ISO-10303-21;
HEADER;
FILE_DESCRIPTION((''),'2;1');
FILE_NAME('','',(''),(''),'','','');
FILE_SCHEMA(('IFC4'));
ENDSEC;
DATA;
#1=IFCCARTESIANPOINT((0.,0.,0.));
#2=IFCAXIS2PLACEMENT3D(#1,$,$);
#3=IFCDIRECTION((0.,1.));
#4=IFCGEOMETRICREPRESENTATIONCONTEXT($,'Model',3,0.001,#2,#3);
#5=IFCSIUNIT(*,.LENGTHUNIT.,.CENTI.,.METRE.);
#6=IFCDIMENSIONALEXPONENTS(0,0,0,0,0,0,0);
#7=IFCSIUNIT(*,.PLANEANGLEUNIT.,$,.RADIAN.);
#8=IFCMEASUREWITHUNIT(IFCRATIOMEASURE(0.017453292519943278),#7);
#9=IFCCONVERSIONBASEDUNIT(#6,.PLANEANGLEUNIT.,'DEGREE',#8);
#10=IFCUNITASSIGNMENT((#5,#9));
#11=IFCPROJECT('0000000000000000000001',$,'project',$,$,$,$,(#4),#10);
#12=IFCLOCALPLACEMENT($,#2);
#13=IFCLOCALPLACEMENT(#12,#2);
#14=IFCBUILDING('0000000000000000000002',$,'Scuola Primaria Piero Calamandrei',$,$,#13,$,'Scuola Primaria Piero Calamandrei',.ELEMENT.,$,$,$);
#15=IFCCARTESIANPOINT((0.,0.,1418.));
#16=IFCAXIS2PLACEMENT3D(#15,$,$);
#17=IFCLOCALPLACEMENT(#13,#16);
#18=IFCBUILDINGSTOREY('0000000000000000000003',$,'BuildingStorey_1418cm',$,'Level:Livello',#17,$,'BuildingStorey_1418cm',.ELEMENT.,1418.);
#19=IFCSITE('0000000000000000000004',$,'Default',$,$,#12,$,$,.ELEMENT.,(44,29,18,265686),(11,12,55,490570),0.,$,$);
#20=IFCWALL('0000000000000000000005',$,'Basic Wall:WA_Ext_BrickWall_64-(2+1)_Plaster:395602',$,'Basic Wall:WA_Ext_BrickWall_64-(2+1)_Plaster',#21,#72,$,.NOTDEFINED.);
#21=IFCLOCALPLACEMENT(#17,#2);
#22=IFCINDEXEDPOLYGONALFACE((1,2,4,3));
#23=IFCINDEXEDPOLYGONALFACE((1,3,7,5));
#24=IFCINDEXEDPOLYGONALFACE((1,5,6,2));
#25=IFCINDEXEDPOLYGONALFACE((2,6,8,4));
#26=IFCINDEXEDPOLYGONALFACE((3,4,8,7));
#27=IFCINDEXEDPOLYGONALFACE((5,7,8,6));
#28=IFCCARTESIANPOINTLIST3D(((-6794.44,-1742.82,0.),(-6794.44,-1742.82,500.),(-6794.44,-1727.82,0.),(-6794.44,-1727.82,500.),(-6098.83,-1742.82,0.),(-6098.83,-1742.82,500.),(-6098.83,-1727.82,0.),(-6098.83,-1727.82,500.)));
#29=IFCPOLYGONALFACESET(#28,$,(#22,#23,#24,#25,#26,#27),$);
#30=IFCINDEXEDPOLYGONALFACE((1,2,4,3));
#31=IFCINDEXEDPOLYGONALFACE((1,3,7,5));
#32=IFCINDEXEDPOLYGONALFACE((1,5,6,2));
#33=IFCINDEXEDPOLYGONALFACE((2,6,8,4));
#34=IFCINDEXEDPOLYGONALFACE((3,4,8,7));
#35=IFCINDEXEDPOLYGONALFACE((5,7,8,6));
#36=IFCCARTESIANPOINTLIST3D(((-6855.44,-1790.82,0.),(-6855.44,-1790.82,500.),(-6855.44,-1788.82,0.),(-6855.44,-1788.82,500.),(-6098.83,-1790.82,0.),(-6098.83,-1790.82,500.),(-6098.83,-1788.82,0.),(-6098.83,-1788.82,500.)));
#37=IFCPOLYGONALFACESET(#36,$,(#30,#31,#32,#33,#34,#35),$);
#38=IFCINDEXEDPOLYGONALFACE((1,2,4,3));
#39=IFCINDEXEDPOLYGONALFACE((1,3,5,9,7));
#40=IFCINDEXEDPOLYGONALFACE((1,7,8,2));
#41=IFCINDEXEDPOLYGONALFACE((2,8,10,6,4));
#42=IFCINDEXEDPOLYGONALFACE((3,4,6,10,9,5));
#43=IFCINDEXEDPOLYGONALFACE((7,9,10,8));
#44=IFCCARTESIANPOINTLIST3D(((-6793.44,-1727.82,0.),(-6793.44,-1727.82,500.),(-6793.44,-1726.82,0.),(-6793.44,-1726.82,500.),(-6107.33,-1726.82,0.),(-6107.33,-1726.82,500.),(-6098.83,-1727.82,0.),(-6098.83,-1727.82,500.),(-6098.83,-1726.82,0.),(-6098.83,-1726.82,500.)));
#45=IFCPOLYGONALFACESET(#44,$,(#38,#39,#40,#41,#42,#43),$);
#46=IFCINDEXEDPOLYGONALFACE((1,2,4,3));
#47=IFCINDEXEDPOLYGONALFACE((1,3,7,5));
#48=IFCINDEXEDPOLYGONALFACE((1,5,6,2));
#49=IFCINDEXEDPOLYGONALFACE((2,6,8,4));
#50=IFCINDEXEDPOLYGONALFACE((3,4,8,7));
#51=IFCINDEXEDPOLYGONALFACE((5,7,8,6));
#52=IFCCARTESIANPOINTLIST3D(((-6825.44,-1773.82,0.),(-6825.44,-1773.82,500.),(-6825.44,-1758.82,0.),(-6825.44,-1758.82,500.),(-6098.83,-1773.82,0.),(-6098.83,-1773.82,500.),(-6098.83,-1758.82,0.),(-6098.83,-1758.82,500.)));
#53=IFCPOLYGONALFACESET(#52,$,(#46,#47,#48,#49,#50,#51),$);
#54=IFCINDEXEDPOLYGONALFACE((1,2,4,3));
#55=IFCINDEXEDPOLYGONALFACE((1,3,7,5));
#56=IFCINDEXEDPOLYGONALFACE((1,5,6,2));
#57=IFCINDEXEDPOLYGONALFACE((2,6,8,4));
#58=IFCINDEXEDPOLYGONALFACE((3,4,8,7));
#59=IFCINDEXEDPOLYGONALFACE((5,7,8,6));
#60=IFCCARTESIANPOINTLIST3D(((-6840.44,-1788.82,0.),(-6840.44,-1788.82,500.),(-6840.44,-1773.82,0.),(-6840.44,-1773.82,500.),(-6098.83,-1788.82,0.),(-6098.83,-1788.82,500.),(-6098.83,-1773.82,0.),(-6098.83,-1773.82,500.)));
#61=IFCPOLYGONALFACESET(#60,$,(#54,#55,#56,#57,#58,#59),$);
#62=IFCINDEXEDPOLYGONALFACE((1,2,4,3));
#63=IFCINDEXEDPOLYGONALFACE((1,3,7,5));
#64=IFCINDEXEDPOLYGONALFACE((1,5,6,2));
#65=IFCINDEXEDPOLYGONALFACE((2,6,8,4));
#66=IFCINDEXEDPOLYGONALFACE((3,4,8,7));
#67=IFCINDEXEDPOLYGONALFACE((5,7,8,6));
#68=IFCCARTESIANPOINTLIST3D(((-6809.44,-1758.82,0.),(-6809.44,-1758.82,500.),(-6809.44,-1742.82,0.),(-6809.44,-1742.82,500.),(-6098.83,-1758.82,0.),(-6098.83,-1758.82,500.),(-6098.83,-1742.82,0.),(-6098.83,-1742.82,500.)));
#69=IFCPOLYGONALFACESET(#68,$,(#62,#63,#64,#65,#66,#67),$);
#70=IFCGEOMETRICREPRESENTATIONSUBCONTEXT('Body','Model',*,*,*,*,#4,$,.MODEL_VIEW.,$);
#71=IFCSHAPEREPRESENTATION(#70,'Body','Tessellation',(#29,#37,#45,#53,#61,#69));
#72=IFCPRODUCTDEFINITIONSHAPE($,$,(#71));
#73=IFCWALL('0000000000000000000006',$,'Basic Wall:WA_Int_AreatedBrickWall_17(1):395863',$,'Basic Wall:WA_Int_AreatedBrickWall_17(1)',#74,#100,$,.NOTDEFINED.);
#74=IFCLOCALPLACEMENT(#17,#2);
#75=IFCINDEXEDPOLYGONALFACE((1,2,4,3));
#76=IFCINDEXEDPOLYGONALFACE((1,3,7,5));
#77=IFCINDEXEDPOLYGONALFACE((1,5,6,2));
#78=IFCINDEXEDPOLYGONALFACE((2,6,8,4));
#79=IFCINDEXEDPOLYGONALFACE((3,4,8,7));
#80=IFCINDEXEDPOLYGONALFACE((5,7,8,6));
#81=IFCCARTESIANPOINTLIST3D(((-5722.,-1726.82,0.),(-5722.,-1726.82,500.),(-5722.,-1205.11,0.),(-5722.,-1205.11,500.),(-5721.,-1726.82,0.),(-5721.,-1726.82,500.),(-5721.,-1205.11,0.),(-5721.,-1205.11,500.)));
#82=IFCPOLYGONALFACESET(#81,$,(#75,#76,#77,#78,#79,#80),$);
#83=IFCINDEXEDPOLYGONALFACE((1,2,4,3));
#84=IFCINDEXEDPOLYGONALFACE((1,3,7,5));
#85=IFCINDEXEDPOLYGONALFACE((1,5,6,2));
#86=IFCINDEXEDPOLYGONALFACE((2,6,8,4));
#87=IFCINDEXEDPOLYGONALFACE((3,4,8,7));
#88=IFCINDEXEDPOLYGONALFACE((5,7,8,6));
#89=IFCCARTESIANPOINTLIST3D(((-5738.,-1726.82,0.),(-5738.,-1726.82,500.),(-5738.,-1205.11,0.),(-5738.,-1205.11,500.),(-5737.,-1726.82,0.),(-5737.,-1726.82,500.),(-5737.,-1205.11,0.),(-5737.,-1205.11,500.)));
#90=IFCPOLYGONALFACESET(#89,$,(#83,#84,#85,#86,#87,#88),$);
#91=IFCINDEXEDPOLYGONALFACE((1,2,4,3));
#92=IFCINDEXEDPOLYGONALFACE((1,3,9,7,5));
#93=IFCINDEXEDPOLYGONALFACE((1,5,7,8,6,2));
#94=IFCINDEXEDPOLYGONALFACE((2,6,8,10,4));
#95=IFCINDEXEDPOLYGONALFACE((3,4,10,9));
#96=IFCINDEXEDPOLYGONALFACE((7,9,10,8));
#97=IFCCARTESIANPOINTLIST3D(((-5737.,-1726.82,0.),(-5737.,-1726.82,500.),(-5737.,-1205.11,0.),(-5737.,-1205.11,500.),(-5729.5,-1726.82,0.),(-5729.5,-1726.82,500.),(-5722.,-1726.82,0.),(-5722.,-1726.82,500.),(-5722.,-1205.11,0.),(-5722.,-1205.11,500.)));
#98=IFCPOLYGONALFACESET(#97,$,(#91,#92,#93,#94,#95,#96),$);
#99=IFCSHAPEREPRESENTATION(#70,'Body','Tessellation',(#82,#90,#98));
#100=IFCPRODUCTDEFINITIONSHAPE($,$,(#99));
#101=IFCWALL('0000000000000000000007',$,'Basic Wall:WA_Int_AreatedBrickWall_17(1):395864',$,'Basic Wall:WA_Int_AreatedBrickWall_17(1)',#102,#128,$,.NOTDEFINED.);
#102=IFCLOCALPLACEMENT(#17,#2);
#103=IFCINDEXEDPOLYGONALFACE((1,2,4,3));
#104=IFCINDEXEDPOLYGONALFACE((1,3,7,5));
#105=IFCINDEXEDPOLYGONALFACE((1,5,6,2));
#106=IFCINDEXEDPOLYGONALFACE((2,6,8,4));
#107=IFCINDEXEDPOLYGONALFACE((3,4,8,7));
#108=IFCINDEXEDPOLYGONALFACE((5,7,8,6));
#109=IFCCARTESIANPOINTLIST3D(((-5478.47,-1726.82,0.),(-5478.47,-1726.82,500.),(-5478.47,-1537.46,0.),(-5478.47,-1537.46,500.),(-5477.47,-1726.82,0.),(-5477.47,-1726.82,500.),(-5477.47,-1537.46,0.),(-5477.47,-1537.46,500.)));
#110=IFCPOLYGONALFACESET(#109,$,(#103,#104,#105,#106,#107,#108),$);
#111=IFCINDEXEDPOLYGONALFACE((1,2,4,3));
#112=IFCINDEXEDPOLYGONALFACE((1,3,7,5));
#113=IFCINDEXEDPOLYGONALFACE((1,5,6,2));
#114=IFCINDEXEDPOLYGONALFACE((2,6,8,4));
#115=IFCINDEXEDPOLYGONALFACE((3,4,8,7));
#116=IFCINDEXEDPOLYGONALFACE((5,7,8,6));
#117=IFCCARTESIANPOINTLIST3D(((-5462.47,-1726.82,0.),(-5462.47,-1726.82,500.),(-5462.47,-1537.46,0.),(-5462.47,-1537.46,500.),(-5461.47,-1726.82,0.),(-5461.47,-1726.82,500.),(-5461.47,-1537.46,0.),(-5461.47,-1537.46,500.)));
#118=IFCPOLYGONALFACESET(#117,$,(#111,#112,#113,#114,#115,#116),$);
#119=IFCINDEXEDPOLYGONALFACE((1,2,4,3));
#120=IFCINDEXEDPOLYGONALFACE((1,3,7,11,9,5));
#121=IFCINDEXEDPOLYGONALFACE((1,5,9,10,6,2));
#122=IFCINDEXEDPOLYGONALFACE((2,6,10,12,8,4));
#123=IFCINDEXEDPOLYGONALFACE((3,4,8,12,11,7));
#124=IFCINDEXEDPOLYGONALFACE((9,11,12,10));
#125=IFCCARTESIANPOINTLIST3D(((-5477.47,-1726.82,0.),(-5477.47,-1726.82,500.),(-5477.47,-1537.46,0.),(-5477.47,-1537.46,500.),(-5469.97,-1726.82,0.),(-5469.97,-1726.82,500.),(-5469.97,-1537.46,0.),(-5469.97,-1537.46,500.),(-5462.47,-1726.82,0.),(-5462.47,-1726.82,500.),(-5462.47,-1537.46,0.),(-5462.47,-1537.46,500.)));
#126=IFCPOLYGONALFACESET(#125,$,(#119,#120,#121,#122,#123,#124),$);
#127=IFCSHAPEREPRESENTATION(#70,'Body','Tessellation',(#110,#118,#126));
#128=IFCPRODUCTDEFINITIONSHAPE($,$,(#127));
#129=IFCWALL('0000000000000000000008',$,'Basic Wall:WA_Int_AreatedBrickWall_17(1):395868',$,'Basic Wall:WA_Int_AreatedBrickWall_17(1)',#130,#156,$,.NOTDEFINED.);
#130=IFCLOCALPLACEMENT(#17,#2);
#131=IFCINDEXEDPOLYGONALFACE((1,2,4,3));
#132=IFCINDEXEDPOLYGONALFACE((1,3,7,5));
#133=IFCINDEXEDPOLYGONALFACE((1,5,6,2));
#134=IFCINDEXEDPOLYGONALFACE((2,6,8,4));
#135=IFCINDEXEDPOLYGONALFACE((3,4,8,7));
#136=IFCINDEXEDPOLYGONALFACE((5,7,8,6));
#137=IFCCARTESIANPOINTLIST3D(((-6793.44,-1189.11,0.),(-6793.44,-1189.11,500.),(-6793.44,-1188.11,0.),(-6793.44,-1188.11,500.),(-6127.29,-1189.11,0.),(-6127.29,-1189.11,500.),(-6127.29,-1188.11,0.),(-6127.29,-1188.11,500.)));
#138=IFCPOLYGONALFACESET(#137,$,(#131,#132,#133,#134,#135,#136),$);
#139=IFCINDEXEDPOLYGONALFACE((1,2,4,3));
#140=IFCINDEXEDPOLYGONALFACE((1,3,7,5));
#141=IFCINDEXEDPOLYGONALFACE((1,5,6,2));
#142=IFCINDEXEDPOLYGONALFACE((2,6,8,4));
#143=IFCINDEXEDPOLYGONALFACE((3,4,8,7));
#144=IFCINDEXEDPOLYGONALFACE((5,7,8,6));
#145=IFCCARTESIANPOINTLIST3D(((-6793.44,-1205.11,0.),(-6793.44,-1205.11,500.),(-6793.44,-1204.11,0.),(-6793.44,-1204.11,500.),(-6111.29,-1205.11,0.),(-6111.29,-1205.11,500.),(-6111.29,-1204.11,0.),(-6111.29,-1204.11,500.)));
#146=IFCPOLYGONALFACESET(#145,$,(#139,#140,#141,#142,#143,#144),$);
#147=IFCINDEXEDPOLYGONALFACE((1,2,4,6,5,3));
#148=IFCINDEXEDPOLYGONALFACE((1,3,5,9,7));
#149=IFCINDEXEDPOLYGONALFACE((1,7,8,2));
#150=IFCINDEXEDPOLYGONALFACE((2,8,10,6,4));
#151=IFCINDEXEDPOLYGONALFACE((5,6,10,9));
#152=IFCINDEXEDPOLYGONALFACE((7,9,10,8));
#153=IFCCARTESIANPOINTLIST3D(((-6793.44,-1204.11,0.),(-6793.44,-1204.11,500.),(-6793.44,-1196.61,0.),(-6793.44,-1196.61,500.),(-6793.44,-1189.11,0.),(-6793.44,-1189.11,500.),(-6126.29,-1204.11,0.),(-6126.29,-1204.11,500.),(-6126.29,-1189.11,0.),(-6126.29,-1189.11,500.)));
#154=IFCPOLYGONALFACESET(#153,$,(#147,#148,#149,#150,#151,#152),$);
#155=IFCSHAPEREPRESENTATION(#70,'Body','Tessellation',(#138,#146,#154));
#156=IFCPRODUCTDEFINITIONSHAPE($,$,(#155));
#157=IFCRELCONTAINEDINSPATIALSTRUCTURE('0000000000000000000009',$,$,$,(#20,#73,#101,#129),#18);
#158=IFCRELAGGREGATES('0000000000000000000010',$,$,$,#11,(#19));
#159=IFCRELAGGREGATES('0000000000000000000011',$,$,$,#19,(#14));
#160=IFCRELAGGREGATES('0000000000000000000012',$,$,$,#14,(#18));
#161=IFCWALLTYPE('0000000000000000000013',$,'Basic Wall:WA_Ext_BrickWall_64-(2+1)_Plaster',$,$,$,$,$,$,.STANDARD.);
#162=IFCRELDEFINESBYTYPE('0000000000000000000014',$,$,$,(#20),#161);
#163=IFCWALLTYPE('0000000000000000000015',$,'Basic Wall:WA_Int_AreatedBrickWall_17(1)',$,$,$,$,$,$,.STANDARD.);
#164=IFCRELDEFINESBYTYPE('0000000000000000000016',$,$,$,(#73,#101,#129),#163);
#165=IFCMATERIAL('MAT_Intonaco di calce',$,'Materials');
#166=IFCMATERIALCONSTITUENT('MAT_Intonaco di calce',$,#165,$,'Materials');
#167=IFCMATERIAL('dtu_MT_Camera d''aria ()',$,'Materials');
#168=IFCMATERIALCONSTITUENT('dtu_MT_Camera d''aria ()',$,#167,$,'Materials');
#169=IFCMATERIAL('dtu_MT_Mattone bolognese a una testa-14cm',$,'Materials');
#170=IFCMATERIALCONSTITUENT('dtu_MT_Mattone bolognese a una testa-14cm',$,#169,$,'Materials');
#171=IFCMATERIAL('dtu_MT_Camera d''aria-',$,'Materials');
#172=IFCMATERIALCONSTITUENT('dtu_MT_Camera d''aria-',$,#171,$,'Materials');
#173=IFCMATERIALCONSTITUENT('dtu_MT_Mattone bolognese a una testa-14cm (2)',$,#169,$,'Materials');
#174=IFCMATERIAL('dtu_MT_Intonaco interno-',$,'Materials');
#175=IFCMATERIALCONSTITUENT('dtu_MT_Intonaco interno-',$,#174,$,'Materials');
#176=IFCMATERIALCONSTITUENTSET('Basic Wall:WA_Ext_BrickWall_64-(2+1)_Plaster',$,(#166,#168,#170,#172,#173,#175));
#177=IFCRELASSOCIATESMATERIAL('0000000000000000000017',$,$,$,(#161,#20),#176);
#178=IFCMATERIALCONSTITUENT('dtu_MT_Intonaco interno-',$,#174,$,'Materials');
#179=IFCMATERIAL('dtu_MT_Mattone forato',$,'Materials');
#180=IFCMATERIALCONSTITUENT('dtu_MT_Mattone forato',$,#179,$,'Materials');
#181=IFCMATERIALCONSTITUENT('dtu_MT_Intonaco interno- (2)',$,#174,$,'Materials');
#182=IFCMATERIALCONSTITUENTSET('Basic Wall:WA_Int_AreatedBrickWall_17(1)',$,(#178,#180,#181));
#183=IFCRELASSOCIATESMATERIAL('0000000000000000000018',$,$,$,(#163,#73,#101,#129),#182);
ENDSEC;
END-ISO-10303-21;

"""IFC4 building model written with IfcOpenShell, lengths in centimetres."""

from ifc_helpers import new_model, entity, si_unit, converted_unit, direction, frame, origin, place, context, subcontext, project, spatial, indexed_curve, outline, extrude, material, constituent, constituent_set, type_object, element, save


model = new_model("IFC4")

# Units and contexts
model_context = context("Model", 3, precision=0.001, world=origin(), true_north=direction((0.0, 1.0)))
body_context = subcontext(model_context, "Body", "Model", "MODEL_VIEW")
ifc_project = project(units=[si_unit("LENGTHUNIT", "METRE", prefix="CENTI"), converted_unit("PLANEANGLEUNIT", "DEGREE", entity("IfcRatioMeasure", 0.017453292519943278), si_unit("PLANEANGLEUNIT", "RADIAN"), dimensions=[0, 0, 0, 0, 0, 0, 0])], contexts=[model_context])

# Site, building, storey
site_placement = place(None, origin())
site = spatial("IfcSite", under=ifc_project, at=site_placement, Name="Default", CompositionType="ELEMENT", RefLatitude=(44, 29, 18, 265686), RefLongitude=(11, 12, 55, 490570), RefElevation=0.0)
building_placement = place(site_placement, origin())
building = spatial("IfcBuilding", under=site, at=building_placement, Name="Scuola Primaria Piero Calamandrei", LongName="Scuola Primaria Piero Calamandrei", CompositionType="ELEMENT")
storey_placement = place(building_placement, frame((0.0, 0.0, 1418.0)))
storey = spatial("IfcBuildingStorey", under=building, at=storey_placement, Name="BuildingStorey_1418cm", ObjectType="Level:Livello", LongName="BuildingStorey_1418cm", CompositionType="ELEMENT", Elevation=1418.0)

# Shared definitions
ifc_material_1 = material(Name="MAT_Intonaco di calce", Category="Materials")
ifc_constituent_1 = constituent(ifc_material_1, Name="MAT_Intonaco di calce", Category="Materials")
ifc_material_2 = material(Name="dtu_MT_Camera d'aria ()", Category="Materials")
ifc_constituent_2 = constituent(ifc_material_2, Name="dtu_MT_Camera d'aria ()", Category="Materials")
ifc_material_3 = material(Name="dtu_MT_Mattone bolognese a una testa-14cm", Category="Materials")
ifc_constituent_3 = constituent(ifc_material_3, Name="dtu_MT_Mattone bolognese a una testa-14cm", Category="Materials")
ifc_material_4 = material(Name="dtu_MT_Camera d'aria-", Category="Materials")
ifc_constituent_4 = constituent(ifc_material_4, Name="dtu_MT_Camera d'aria-", Category="Materials")
ifc_constituent_5 = constituent(ifc_material_3, Name="dtu_MT_Mattone bolognese a una testa-14cm (2)", Category="Materials")
ifc_material_5 = material(Name="dtu_MT_Intonaco interno-", Category="Materials")
ifc_constituent_6 = constituent(ifc_material_5, Name="dtu_MT_Intonaco interno-", Category="Materials")
ifc_constituent_set_1 = constituent_set(constituents=[ifc_constituent_1, ifc_constituent_2, ifc_constituent_3, ifc_constituent_4, ifc_constituent_5, ifc_constituent_6], Name="Basic Wall:WA_Ext_BrickWall_64-(2+1)_Plaster")
wall_type_1 = type_object("IfcWallType", Name="Basic Wall:WA_Ext_BrickWall_64-(2+1)_Plaster", PredefinedType="STANDARD", material=ifc_constituent_set_1)

# Wall
wall_1_placement = place(storey_placement, frame((-6098.83, -1758.82, 0.0), z_axis=(0.0, 0.0, 1.0), x_axis=(-1.0, 0.0, 0.0)))
element("IfcWall", 1, at=wall_1_placement, inside=storey, type_object=wall_type_1, material=ifc_constituent_set_1, Name="Basic Wall:WA_Ext_BrickWall_64-(2+1)_Plaster:395602", ObjectType="Basic Wall:WA_Ext_BrickWall_64-(2+1)_Plaster", PredefinedType="NOTDEFINED", context=body_context, shape_type="SweptSolid", body=[
    extrude(outline(indexed_curve([(-347.81, -7.5), (347.81, -7.5), (347.81, 7.5), (-347.81, 7.5), (-347.81, -7.5)], self_intersect=False)), frame((347.81, -23.5, 0.0)), (0.0, 0.0, 1.0), 500.0),
    extrude(outline(indexed_curve([(-1.0, -378.31), (1.0, -378.31), (1.0, 378.31), (-1.0, 378.31), (-1.0, -378.31)], self_intersect=False)), frame((378.31, 31.0, 0.0), z_axis=(0.0, 0.0, 1.0), x_axis=(0.0, -1.0, 0.0)), (0.0, 0.0, 1.0), 500.0),
    extrude(outline(indexed_curve([(-271.05, -0.4), (415.07, -0.4), (415.07, 0.6), (-279.55, 0.6), (-279.55, -0.4), (-271.05, -0.4)], self_intersect=False)), frame((279.55, -31.6, 0.0)), (0.0, 0.0, 1.0), 500.0),
    extrude(outline(indexed_curve([(-363.31, -7.5), (363.31, -7.5), (363.31, 7.5), (-363.31, 7.5), (-363.31, -7.5)], self_intersect=False)), frame((363.31, 7.5, 0.0)), (0.0, 0.0, 1.0), 500.0),
    extrude(outline(indexed_curve([(-370.81, -7.5), (370.81, -7.5), (370.81, 7.5), (-370.81, 7.5), (-370.81, -7.5)], self_intersect=False)), frame((370.81, 22.5, 0.0)), (0.0, 0.0, 1.0), 500.0),
    extrude(outline(indexed_curve([(-355.31, -8.0), (355.31, -8.0), (355.31, 8.0), (-355.31, 8.0), (-355.31, -8.0)], self_intersect=False)), frame((355.31, -8.0, 0.0)), (0.0, 0.0, 1.0), 500.0),
])

# Shared definitions
ifc_constituent_7 = constituent(ifc_material_5, Name="dtu_MT_Intonaco interno-", Category="Materials")
ifc_material_6 = material(Name="dtu_MT_Mattone forato", Category="Materials")
ifc_constituent_8 = constituent(ifc_material_6, Name="dtu_MT_Mattone forato", Category="Materials")
ifc_constituent_9 = constituent(ifc_material_5, Name="dtu_MT_Intonaco interno- (2)", Category="Materials")
ifc_constituent_set_2 = constituent_set(constituents=[ifc_constituent_7, ifc_constituent_8, ifc_constituent_9], Name="Basic Wall:WA_Int_AreatedBrickWall_17(1)")
wall_type_2 = type_object("IfcWallType", Name="Basic Wall:WA_Int_AreatedBrickWall_17(1)", PredefinedType="STANDARD", material=ifc_constituent_set_2)

# Walls
wall_2_placement = place(storey_placement, frame((-5729.5, -1726.82, 0.0), z_axis=(0.0, 0.0, 1.0), x_axis=(0.0, 1.0, 0.0)))
element("IfcWall", 2, at=wall_2_placement, inside=storey, type_object=wall_type_2, material=ifc_constituent_set_2, Name="Basic Wall:WA_Int_AreatedBrickWall_17(1):395863", ObjectType="Basic Wall:WA_Int_AreatedBrickWall_17(1)", PredefinedType="NOTDEFINED", context=body_context, shape_type="SweptSolid", body=[
    extrude(outline(indexed_curve([(-0.5, -260.86), (0.5, -260.86), (0.5, 260.86), (-0.5, 260.86), (-0.5, -260.86)], self_intersect=False)), frame((260.86, -8.0, 0.0), z_axis=(0.0, 0.0, 1.0), x_axis=(0.0, 1.0, 0.0)), (0.0, 0.0, 1.0), 500.0),
    extrude(outline(indexed_curve([(-0.5, -260.86), (0.5, -260.86), (0.5, 260.86), (-0.5, 260.86), (-0.5, -260.86)], self_intersect=False)), frame((260.86, 8.0, 0.0), z_axis=(0.0, 0.0, 1.0), x_axis=(0.0, -1.0, 0.0)), (0.0, 0.0, 1.0), 500.0),
    extrude(outline(indexed_curve([(-208.69, -7.5), (313.03, -7.5), (313.03, 7.5), (-208.69, 7.5), (-208.69, 0.0), (-208.69, -7.5)], self_intersect=False)), frame((208.69, 0.0, 0.0)), (0.0, 0.0, 1.0), 500.0),
])
wall_3_placement = place(storey_placement, frame((-5469.97, -1537.46, 0.0), z_axis=(0.0, 0.0, 1.0), x_axis=(0.0, -1.0, 0.0)))
element("IfcWall", 3, at=wall_3_placement, inside=storey, type_object=wall_type_2, material=ifc_constituent_set_2, Name="Basic Wall:WA_Int_AreatedBrickWall_17(1):395864", ObjectType="Basic Wall:WA_Int_AreatedBrickWall_17(1)", PredefinedType="NOTDEFINED", context=body_context, shape_type="SweptSolid", body=[
    extrude(outline(indexed_curve([(-0.5, -94.68), (0.5, -94.68), (0.5, 94.68), (-0.5, 94.68), (-0.5, -94.68)], self_intersect=False)), frame((94.68, -8.0, 0.0), z_axis=(0.0, 0.0, 1.0), x_axis=(0.0, 1.0, 0.0)), (0.0, 0.0, 1.0), 500.0),
    extrude(outline(indexed_curve([(-0.5, -94.68), (0.5, -94.68), (0.5, 94.68), (-0.5, 94.68), (-0.5, -94.68)], self_intersect=False)), frame((94.68, 8.0, 0.0), z_axis=(0.0, 0.0, 1.0), x_axis=(0.0, -1.0, 0.0)), (0.0, 0.0, 1.0), 500.0),
    extrude(outline(indexed_curve([(-94.68, -7.5), (94.68, -7.5), (94.68, 0.0), (94.68, 7.5), (-94.68, 7.5), (-94.68, 0.0), (-94.68, -7.5)], self_intersect=False)), frame((94.68, 0.0, 0.0)), (0.0, 0.0, 1.0), 500.0),
])

# Wall
wall_4_placement = place(storey_placement, frame((-6127.29, -1196.61, 0.0), z_axis=(0.0, 0.0, 1.0), x_axis=(-1.0, 0.0, 0.0)))
element("IfcWall", 4, at=wall_4_placement, inside=storey, type_object=wall_type_2, material=ifc_constituent_set_2, Name="Basic Wall:WA_Int_AreatedBrickWall_17(1):395868", ObjectType="Basic Wall:WA_Int_AreatedBrickWall_17(1)", PredefinedType="NOTDEFINED", context=body_context, shape_type="SweptSolid", body=[
    extrude(outline(indexed_curve([(-0.5, -333.08), (0.5, -333.08), (0.5, 333.08), (-0.5, 333.08), (-0.5, -333.08)], self_intersect=False)), frame((333.08, -8.0, 0.0), z_axis=(0.0, 0.0, 1.0), x_axis=(0.0, 1.0, 0.0)), (0.0, 0.0, 1.0), 500.0),
    extrude(outline(indexed_curve([(-0.5, -341.08), (0.5, -341.08), (0.5, 341.08), (-0.5, 341.08), (-0.5, -341.08)], self_intersect=False)), frame((325.08, 8.0, 0.0), z_axis=(0.0, 0.0, 1.0), x_axis=(0.0, -1.0, 0.0)), (0.0, 0.0, 1.0), 500.0),
    extrude(outline(indexed_curve([(-400.29, -7.5), (266.86, -7.5), (266.86, 0.0), (266.86, 7.5), (-400.29, 7.5), (-400.29, -7.5)], self_intersect=False)), frame((399.29, 0.0, 0.0)), (0.0, 0.0, 1.0), 500.0),
])

save(model, "model.ifc")
